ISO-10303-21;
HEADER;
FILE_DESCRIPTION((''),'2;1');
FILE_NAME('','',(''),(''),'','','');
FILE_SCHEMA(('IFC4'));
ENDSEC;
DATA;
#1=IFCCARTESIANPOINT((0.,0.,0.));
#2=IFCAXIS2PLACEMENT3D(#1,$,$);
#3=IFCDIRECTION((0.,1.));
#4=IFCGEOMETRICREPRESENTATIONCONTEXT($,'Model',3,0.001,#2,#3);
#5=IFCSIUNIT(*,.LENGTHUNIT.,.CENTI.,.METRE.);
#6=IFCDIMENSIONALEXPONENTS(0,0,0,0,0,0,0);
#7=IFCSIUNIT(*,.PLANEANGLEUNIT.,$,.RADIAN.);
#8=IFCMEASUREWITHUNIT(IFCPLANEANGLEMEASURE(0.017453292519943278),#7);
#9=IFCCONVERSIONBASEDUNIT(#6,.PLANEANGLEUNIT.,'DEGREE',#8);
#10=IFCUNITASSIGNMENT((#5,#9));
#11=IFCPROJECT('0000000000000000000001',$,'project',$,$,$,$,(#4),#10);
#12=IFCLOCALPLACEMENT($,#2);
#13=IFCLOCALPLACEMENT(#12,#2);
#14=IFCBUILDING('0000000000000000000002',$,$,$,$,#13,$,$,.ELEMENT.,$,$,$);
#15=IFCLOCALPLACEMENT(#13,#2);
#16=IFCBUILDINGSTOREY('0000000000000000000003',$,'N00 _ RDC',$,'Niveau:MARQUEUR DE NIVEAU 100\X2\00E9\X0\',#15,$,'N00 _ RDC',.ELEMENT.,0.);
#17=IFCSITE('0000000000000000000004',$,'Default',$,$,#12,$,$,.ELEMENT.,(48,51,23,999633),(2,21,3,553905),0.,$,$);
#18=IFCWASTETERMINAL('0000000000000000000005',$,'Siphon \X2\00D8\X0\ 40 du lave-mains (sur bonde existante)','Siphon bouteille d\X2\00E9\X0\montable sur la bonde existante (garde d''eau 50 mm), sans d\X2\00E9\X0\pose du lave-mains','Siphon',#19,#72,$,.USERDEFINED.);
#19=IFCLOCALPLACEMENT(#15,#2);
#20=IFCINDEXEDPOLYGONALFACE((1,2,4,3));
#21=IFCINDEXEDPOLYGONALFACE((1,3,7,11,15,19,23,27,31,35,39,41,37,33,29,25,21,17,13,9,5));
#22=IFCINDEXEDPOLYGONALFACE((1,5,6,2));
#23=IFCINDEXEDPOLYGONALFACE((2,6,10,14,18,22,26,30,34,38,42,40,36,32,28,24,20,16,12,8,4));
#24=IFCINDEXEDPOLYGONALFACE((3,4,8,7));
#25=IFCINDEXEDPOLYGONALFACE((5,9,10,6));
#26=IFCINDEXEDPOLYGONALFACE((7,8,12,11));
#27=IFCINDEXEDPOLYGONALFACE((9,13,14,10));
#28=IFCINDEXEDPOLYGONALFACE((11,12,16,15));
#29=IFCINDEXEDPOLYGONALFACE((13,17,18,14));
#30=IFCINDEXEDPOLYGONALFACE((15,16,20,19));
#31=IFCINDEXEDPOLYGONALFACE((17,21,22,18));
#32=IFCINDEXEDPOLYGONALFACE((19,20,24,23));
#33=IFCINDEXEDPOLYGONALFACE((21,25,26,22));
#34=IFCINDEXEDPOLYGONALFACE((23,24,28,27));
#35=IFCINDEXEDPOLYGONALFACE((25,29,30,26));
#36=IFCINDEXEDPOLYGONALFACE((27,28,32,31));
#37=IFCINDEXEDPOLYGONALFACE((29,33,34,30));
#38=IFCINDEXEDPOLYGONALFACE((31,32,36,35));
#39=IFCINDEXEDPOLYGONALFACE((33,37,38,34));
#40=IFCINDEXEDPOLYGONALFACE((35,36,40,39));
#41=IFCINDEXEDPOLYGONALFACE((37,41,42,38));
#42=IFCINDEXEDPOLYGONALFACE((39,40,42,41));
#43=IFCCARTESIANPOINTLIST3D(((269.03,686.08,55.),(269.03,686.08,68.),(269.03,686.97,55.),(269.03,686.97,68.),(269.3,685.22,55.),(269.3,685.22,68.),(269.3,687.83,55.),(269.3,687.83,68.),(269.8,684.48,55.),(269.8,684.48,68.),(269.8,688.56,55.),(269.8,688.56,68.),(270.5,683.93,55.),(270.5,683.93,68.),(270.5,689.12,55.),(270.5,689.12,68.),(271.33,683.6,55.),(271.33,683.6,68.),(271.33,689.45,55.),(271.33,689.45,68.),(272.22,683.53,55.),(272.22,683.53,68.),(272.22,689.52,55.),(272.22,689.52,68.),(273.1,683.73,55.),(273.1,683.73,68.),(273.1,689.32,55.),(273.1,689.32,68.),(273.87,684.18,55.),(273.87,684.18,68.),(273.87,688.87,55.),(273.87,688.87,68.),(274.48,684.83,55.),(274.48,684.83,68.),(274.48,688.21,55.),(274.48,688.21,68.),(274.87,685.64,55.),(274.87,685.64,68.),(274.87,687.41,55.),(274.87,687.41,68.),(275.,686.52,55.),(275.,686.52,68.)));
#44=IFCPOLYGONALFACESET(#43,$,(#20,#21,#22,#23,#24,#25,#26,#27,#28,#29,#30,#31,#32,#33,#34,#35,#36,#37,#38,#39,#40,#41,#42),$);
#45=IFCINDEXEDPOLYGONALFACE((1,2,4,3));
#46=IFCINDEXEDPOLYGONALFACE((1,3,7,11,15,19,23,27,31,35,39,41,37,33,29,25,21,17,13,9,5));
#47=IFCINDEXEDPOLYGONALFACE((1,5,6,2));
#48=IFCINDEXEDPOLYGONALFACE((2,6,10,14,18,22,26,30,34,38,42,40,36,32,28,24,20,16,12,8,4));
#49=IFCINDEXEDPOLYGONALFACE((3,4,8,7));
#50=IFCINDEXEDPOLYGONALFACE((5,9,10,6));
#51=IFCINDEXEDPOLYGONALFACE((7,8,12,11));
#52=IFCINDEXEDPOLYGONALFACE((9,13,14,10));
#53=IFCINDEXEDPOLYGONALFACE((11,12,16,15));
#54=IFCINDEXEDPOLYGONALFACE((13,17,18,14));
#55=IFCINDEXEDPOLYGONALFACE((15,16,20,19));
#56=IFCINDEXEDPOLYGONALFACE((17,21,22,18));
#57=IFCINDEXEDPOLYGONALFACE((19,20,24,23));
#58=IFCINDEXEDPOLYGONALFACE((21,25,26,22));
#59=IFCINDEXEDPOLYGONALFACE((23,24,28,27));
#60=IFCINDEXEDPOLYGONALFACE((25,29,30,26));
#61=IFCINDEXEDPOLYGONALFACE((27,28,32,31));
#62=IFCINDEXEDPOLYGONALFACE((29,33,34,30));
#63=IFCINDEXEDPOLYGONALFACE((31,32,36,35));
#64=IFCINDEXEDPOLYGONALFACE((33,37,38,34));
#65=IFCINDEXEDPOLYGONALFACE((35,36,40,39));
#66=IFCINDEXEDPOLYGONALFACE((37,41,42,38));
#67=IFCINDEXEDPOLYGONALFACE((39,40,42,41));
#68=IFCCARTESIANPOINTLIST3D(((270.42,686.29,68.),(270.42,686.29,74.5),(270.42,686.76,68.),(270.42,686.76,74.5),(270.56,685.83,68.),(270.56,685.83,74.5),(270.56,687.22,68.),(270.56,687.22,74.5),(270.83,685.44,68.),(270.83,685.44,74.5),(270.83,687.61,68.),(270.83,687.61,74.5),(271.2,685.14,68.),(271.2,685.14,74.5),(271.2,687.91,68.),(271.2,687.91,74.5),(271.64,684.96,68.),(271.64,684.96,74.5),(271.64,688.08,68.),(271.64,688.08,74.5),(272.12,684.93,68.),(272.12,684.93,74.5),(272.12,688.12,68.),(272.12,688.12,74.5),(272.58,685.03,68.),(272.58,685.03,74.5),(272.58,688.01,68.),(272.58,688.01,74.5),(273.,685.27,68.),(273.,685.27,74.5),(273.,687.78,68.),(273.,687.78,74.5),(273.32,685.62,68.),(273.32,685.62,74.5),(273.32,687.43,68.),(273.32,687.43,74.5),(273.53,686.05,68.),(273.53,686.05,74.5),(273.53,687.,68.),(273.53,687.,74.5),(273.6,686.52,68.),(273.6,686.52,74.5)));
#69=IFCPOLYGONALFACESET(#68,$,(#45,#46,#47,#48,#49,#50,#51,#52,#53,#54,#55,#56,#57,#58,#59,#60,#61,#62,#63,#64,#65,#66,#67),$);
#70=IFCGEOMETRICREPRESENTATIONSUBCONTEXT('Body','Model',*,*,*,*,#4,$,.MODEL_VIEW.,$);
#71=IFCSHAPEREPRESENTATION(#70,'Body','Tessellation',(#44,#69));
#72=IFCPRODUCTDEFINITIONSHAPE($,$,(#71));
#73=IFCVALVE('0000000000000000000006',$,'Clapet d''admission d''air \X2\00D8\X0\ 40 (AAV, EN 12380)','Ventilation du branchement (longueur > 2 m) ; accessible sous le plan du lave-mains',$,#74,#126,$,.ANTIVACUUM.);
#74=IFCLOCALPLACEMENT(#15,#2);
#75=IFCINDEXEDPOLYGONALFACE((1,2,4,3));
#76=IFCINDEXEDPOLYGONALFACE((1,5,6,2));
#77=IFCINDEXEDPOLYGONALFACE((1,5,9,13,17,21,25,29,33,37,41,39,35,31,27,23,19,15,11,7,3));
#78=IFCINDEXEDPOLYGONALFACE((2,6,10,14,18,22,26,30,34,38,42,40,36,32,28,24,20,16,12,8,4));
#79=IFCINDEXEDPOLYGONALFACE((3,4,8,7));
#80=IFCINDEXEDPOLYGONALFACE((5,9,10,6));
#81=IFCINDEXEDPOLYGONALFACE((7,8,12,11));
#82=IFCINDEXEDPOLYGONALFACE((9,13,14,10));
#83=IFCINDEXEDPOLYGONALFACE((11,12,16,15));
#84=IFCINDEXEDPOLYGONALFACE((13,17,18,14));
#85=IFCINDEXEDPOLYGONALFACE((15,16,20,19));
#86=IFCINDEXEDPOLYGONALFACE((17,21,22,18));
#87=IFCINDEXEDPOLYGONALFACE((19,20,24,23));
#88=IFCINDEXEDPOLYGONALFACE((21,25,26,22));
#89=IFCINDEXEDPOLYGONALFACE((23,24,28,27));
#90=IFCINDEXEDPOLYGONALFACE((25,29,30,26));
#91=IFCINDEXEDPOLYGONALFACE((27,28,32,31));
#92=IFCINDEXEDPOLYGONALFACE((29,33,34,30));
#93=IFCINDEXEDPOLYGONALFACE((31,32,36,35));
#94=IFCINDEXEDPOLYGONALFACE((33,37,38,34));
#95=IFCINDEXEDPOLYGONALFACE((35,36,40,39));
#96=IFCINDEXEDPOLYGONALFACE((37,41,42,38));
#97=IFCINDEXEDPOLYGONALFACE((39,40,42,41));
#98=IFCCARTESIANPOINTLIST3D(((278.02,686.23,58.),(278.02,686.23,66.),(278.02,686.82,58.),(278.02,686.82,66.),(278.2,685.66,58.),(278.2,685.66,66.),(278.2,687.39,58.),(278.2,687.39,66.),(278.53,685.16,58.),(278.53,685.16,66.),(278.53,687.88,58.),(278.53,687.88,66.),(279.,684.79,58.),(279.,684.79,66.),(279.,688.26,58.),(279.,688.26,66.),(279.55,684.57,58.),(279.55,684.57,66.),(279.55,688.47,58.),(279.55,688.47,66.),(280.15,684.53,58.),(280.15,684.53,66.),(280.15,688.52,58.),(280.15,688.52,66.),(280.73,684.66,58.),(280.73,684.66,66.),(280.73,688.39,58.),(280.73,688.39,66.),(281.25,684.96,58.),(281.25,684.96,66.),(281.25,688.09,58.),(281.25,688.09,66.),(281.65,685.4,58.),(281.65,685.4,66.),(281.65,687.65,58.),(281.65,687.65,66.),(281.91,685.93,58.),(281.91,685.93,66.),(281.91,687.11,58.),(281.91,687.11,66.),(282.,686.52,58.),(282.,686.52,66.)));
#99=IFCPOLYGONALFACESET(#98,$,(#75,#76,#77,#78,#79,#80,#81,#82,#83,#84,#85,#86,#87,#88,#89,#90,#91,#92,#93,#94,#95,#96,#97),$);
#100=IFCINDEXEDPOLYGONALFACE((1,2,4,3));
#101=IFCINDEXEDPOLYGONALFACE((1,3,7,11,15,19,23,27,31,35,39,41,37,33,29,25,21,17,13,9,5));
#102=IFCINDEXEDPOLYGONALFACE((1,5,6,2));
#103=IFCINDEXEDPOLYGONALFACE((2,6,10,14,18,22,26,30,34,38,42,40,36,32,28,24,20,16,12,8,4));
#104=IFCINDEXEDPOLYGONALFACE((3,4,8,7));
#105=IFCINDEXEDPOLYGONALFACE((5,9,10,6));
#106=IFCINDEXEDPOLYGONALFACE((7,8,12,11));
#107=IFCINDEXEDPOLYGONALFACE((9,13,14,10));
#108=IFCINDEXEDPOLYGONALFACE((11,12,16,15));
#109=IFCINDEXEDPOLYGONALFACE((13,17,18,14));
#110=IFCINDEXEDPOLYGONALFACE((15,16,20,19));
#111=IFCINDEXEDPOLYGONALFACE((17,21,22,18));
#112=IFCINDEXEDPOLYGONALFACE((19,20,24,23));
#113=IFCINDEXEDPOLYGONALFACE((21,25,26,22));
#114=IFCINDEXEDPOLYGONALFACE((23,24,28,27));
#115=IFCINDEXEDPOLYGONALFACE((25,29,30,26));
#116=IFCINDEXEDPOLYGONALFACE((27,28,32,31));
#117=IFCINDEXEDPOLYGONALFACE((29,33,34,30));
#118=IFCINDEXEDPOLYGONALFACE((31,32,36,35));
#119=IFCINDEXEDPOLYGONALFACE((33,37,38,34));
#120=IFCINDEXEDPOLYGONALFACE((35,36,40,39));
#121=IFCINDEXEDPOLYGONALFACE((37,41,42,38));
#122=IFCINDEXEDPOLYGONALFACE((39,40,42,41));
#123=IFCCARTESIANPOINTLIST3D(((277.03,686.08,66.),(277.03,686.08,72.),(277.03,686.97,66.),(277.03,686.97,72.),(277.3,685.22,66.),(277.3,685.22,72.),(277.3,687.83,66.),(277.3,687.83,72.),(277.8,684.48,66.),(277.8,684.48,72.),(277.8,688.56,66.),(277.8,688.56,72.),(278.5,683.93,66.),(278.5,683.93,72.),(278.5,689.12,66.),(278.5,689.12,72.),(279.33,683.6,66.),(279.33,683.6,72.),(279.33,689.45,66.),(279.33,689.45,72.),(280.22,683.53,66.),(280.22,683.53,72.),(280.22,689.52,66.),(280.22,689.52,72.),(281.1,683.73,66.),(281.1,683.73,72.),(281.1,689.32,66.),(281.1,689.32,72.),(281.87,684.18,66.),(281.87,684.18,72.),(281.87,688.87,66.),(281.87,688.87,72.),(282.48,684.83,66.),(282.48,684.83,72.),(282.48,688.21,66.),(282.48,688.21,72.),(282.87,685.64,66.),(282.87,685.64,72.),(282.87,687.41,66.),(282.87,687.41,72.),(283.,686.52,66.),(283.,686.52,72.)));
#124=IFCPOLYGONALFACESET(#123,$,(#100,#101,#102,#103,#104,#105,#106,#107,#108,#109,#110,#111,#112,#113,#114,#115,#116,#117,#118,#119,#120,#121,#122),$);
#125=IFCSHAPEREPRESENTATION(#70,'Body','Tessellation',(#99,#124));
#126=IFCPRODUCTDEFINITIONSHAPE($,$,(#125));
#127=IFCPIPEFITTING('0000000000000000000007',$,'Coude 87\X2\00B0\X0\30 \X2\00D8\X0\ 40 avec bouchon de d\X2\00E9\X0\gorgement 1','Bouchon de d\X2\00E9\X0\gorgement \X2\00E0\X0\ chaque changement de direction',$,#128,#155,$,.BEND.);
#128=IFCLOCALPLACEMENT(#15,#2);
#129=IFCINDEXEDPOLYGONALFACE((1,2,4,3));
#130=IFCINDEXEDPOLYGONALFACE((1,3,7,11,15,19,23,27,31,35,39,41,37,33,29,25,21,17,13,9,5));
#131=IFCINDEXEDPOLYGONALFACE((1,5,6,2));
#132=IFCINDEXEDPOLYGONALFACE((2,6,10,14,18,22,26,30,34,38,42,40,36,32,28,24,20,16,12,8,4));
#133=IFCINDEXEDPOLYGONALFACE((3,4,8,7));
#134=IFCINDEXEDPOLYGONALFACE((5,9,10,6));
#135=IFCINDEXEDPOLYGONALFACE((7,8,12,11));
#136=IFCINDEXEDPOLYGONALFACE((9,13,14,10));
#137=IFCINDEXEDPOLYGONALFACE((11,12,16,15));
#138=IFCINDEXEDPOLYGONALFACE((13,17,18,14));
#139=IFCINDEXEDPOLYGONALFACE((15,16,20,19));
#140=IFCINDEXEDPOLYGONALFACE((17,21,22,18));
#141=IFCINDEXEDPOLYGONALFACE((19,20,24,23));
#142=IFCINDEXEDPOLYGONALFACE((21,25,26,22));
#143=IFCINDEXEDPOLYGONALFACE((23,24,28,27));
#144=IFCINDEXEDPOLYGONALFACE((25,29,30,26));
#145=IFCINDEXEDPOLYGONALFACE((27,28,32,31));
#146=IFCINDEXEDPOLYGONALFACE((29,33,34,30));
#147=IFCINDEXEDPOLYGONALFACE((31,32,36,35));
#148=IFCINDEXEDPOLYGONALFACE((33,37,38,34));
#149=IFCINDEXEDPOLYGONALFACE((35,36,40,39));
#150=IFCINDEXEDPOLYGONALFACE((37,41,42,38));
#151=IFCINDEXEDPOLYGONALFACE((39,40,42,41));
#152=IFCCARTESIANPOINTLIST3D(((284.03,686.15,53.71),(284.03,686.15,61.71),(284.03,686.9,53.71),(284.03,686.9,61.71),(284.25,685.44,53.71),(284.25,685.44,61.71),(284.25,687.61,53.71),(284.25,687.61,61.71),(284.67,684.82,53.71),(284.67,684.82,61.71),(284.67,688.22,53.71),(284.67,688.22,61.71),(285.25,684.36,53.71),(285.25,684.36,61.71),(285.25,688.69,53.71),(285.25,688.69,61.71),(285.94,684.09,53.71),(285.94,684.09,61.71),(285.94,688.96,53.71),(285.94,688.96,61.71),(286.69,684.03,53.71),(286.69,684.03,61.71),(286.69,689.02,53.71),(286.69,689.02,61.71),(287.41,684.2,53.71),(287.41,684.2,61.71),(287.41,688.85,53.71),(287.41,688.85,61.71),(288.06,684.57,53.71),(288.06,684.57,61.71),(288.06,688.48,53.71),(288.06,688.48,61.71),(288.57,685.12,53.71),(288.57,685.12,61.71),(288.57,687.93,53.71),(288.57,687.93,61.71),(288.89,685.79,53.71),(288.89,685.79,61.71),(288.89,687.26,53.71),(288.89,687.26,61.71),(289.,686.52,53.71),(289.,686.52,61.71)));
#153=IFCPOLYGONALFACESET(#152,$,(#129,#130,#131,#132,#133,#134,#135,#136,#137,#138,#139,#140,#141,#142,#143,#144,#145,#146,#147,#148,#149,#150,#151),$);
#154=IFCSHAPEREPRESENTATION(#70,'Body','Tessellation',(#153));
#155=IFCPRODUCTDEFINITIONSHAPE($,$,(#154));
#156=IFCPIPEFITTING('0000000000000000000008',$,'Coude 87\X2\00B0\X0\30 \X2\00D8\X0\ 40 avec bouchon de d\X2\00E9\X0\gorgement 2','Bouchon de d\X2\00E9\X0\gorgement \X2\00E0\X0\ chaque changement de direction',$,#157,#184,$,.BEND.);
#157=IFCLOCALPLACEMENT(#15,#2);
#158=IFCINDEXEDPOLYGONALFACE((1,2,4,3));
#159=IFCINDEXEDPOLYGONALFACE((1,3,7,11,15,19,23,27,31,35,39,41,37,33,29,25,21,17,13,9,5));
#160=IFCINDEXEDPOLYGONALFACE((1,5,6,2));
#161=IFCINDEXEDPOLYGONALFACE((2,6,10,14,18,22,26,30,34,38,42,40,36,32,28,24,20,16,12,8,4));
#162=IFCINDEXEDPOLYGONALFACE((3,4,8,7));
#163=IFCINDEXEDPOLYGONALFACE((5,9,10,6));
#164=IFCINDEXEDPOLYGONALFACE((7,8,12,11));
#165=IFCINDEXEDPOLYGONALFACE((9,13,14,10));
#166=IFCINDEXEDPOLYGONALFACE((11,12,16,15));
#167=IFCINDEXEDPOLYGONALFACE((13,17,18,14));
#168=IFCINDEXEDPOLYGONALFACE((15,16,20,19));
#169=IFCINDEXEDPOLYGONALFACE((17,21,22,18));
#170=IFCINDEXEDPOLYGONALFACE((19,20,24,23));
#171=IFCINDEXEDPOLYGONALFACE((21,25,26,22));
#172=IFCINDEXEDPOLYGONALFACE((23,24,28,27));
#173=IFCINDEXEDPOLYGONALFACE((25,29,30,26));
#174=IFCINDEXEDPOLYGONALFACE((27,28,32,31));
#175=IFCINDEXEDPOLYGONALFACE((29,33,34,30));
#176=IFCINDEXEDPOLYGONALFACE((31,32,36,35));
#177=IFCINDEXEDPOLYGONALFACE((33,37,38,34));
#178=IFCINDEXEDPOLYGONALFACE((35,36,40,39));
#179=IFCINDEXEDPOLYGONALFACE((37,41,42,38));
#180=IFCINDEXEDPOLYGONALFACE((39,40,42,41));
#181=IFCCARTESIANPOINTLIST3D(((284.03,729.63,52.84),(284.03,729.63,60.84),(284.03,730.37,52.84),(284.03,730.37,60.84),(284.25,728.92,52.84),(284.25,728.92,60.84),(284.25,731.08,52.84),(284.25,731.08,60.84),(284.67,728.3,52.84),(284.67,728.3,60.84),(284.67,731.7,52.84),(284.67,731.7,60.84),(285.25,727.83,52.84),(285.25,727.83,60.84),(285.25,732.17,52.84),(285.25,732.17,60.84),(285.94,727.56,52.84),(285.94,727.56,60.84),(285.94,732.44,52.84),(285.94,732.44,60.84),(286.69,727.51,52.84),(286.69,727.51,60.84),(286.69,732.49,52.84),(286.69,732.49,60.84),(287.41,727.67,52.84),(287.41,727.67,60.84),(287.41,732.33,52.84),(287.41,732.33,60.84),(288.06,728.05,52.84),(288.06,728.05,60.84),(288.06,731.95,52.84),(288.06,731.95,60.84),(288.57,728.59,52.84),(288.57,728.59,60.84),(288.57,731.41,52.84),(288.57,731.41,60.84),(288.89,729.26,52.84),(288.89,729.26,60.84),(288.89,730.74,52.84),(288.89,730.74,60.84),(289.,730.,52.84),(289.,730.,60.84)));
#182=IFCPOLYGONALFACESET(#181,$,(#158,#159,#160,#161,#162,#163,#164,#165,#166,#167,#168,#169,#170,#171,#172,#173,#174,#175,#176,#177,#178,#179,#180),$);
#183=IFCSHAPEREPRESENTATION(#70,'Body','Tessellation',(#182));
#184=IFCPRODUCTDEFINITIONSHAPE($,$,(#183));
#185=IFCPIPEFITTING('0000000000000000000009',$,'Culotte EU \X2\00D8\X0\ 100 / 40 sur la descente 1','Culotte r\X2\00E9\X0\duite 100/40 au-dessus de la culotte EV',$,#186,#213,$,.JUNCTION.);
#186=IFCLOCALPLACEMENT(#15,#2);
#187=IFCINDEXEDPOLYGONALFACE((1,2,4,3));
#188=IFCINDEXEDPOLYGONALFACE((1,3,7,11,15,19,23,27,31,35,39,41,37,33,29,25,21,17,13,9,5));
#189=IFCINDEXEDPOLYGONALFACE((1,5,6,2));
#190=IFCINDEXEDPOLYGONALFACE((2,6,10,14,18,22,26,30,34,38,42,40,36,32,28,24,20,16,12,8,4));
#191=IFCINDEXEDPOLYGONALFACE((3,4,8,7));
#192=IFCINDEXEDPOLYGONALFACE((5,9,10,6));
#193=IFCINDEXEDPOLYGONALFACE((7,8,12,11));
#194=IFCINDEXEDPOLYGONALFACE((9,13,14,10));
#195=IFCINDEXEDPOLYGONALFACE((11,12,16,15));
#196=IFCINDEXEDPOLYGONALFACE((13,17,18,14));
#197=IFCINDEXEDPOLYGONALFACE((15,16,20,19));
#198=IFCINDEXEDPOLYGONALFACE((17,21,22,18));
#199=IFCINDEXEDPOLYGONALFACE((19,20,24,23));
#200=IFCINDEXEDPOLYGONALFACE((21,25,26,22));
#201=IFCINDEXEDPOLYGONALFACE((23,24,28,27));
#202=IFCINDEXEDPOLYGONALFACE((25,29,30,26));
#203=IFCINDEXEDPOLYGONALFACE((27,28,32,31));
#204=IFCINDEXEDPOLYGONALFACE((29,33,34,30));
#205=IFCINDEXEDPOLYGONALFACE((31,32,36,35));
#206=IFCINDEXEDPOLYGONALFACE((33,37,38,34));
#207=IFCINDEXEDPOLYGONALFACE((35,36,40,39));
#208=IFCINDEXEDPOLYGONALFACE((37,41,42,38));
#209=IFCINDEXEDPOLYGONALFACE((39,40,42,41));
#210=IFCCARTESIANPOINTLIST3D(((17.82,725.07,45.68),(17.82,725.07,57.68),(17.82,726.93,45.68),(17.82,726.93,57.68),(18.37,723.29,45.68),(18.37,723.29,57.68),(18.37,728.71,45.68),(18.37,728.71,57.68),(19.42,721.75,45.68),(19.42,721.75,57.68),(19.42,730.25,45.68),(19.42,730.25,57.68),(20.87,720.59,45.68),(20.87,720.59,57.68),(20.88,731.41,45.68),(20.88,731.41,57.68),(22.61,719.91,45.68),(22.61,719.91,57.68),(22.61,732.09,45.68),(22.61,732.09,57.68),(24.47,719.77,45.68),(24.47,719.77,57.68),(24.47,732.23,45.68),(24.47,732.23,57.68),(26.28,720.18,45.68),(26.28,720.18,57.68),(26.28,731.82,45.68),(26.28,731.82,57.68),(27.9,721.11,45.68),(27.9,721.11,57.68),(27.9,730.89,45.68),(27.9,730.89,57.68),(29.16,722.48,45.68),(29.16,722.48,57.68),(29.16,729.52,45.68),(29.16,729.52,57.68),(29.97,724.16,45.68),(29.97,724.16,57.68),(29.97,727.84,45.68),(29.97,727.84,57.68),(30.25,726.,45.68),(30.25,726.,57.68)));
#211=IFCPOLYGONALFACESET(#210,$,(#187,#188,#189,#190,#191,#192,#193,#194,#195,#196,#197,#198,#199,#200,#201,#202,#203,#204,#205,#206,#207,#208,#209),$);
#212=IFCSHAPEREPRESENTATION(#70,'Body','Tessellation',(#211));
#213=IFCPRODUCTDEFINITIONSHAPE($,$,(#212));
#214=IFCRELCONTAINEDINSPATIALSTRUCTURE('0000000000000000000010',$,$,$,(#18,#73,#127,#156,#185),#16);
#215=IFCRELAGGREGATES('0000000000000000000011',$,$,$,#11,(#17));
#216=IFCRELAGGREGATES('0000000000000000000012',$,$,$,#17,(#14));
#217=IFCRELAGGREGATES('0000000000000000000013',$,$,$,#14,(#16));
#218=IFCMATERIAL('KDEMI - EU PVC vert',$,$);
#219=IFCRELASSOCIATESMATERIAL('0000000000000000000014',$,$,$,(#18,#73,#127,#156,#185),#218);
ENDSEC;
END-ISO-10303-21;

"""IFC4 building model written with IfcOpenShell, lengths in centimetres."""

from ifc_helpers import new_model, entity, si_unit, converted_unit, direction, frame, frame_2d, origin, origin_with_axes, place, context, subcontext, project, spatial, circle, extrude, material, element, save


model = new_model("IFC4")

# Units and contexts
model_context = context("Model", 3, precision=0.001, world=origin(), true_north=direction((0.0, 1.0)))
body_context = subcontext(model_context, "Body", "Model", "MODEL_VIEW")
ifc_project = project(units=[si_unit("LENGTHUNIT", "METRE", prefix="CENTI"), converted_unit("PLANEANGLEUNIT", "DEGREE", entity("IfcPlaneAngleMeasure", 0.017453292519943278), si_unit("PLANEANGLEUNIT", "RADIAN"), dimensions=[0, 0, 0, 0, 0, 0, 0])], contexts=[model_context])

# Site, building, storey
site_placement = place(None, origin())
site = spatial("IfcSite", under=ifc_project, at=site_placement, Name="Default", CompositionType="ELEMENT", RefLatitude=(48, 51, 23, 999633), RefLongitude=(2, 21, 3, 553905), RefElevation=0.0)
building_placement = place(site_placement, origin())
building = spatial("IfcBuilding", under=site, at=building_placement, CompositionType="ELEMENT")
storey_placement = place(building_placement, origin())
storey = spatial("IfcBuildingStorey", under=building, at=storey_placement, Name="N00 _ RDC", ObjectType="Niveau:MARQUEUR DE NIVEAU 100é", LongName="N00 _ RDC", CompositionType="ELEMENT", Elevation=0.0)

# Shared definitions
ifc_material_1 = material(Name="KDEMI - EU PVC vert")

# Waste terminal
waste_terminal_placement = place(storey_placement, origin_with_axes())
element("IfcWasteTerminal", 1, at=waste_terminal_placement, inside=storey, material=ifc_material_1, Name="Siphon Ø 40 du lave-mains (sur bonde existante)", Description="Siphon bouteille démontable sur la bonde existante (garde d'eau 50 mm), sans dépose du lave-mains", ObjectType="Siphon", PredefinedType="USERDEFINED", context=body_context, shape_type="SweptSolid", body=[
    extrude(circle(Radius=3.0, at=frame_2d((272.0, 686.52))), frame((0.0, 0.0, 55.0)), (0.0, 0.0, 1.0), 13.0),
    extrude(circle(Radius=1.6, at=frame_2d((272.0, 686.52))), frame((0.0, 0.0, 68.0)), (0.0, 0.0, 1.0), 6.5),
])

# Valve
valve_1_placement = place(storey_placement, origin_with_axes())
element("IfcValve", 2, at=valve_1_placement, inside=storey, material=ifc_material_1, Name="Clapet d'admission d'air Ø 40 (AAV, EN 12380)", Description="Ventilation du branchement (longueur > 2 m) ; accessible sous le plan du lave-mains", PredefinedType="ANTIVACUUM", context=body_context, shape_type="AdvancedSweptSolid", body=[
    entity("IfcSweptDiskSolid", entity("IfcPolyline", [entity("IfcCartesianPoint", [280.0, 686.52, 58.0]), entity("IfcCartesianPoint", [280.0, 686.52, 66.0])]), 2.0),
    extrude(circle(Radius=3.0, at=frame_2d((280.0, 686.52))), frame((0.0, 0.0, 66.0)), (0.0, 0.0, 1.0), 6.0),
])

# Pipe fittings
pipe_fitting_1_placement = place(storey_placement, origin_with_axes())
element("IfcPipeFitting", 3, at=pipe_fitting_1_placement, inside=storey, material=ifc_material_1, Name="Coude 87°30 Ø 40 avec bouchon de dégorgement 1", Description="Bouchon de dégorgement à chaque changement de direction", PredefinedType="BEND", context=body_context, shape_type="SweptSolid", body=[
    extrude(circle(Radius=2.5, at=frame_2d((286.5, 686.52))), frame((0.0, 0.0, 53.71)), (0.0, 0.0, 1.0), 8.0),
])
pipe_fitting_2_placement = place(storey_placement, origin_with_axes())
element("IfcPipeFitting", 4, at=pipe_fitting_2_placement, inside=storey, material=ifc_material_1, Name="Coude 87°30 Ø 40 avec bouchon de dégorgement 2", Description="Bouchon de dégorgement à chaque changement de direction", PredefinedType="BEND", context=body_context, shape_type="SweptSolid", body=[
    extrude(circle(Radius=2.5, at=frame_2d((286.5, 730.0))), frame((0.0, 0.0, 52.84)), (0.0, 0.0, 1.0), 8.0),
])
pipe_fitting_3_placement = place(storey_placement, origin_with_axes())
element("IfcPipeFitting", 5, at=pipe_fitting_3_placement, inside=storey, material=ifc_material_1, Name="Culotte EU Ø 100 / 40 sur la descente 1", Description="Culotte réduite 100/40 au-dessus de la culotte EV", PredefinedType="JUNCTION", context=body_context, shape_type="SweptSolid", body=[
    extrude(circle(Radius=6.25, at=frame_2d((24.0, 726.0))), frame((0.0, 0.0, 45.68)), (0.0, 0.0, 1.0), 12.0),
])

save(model, "model.ifc")
